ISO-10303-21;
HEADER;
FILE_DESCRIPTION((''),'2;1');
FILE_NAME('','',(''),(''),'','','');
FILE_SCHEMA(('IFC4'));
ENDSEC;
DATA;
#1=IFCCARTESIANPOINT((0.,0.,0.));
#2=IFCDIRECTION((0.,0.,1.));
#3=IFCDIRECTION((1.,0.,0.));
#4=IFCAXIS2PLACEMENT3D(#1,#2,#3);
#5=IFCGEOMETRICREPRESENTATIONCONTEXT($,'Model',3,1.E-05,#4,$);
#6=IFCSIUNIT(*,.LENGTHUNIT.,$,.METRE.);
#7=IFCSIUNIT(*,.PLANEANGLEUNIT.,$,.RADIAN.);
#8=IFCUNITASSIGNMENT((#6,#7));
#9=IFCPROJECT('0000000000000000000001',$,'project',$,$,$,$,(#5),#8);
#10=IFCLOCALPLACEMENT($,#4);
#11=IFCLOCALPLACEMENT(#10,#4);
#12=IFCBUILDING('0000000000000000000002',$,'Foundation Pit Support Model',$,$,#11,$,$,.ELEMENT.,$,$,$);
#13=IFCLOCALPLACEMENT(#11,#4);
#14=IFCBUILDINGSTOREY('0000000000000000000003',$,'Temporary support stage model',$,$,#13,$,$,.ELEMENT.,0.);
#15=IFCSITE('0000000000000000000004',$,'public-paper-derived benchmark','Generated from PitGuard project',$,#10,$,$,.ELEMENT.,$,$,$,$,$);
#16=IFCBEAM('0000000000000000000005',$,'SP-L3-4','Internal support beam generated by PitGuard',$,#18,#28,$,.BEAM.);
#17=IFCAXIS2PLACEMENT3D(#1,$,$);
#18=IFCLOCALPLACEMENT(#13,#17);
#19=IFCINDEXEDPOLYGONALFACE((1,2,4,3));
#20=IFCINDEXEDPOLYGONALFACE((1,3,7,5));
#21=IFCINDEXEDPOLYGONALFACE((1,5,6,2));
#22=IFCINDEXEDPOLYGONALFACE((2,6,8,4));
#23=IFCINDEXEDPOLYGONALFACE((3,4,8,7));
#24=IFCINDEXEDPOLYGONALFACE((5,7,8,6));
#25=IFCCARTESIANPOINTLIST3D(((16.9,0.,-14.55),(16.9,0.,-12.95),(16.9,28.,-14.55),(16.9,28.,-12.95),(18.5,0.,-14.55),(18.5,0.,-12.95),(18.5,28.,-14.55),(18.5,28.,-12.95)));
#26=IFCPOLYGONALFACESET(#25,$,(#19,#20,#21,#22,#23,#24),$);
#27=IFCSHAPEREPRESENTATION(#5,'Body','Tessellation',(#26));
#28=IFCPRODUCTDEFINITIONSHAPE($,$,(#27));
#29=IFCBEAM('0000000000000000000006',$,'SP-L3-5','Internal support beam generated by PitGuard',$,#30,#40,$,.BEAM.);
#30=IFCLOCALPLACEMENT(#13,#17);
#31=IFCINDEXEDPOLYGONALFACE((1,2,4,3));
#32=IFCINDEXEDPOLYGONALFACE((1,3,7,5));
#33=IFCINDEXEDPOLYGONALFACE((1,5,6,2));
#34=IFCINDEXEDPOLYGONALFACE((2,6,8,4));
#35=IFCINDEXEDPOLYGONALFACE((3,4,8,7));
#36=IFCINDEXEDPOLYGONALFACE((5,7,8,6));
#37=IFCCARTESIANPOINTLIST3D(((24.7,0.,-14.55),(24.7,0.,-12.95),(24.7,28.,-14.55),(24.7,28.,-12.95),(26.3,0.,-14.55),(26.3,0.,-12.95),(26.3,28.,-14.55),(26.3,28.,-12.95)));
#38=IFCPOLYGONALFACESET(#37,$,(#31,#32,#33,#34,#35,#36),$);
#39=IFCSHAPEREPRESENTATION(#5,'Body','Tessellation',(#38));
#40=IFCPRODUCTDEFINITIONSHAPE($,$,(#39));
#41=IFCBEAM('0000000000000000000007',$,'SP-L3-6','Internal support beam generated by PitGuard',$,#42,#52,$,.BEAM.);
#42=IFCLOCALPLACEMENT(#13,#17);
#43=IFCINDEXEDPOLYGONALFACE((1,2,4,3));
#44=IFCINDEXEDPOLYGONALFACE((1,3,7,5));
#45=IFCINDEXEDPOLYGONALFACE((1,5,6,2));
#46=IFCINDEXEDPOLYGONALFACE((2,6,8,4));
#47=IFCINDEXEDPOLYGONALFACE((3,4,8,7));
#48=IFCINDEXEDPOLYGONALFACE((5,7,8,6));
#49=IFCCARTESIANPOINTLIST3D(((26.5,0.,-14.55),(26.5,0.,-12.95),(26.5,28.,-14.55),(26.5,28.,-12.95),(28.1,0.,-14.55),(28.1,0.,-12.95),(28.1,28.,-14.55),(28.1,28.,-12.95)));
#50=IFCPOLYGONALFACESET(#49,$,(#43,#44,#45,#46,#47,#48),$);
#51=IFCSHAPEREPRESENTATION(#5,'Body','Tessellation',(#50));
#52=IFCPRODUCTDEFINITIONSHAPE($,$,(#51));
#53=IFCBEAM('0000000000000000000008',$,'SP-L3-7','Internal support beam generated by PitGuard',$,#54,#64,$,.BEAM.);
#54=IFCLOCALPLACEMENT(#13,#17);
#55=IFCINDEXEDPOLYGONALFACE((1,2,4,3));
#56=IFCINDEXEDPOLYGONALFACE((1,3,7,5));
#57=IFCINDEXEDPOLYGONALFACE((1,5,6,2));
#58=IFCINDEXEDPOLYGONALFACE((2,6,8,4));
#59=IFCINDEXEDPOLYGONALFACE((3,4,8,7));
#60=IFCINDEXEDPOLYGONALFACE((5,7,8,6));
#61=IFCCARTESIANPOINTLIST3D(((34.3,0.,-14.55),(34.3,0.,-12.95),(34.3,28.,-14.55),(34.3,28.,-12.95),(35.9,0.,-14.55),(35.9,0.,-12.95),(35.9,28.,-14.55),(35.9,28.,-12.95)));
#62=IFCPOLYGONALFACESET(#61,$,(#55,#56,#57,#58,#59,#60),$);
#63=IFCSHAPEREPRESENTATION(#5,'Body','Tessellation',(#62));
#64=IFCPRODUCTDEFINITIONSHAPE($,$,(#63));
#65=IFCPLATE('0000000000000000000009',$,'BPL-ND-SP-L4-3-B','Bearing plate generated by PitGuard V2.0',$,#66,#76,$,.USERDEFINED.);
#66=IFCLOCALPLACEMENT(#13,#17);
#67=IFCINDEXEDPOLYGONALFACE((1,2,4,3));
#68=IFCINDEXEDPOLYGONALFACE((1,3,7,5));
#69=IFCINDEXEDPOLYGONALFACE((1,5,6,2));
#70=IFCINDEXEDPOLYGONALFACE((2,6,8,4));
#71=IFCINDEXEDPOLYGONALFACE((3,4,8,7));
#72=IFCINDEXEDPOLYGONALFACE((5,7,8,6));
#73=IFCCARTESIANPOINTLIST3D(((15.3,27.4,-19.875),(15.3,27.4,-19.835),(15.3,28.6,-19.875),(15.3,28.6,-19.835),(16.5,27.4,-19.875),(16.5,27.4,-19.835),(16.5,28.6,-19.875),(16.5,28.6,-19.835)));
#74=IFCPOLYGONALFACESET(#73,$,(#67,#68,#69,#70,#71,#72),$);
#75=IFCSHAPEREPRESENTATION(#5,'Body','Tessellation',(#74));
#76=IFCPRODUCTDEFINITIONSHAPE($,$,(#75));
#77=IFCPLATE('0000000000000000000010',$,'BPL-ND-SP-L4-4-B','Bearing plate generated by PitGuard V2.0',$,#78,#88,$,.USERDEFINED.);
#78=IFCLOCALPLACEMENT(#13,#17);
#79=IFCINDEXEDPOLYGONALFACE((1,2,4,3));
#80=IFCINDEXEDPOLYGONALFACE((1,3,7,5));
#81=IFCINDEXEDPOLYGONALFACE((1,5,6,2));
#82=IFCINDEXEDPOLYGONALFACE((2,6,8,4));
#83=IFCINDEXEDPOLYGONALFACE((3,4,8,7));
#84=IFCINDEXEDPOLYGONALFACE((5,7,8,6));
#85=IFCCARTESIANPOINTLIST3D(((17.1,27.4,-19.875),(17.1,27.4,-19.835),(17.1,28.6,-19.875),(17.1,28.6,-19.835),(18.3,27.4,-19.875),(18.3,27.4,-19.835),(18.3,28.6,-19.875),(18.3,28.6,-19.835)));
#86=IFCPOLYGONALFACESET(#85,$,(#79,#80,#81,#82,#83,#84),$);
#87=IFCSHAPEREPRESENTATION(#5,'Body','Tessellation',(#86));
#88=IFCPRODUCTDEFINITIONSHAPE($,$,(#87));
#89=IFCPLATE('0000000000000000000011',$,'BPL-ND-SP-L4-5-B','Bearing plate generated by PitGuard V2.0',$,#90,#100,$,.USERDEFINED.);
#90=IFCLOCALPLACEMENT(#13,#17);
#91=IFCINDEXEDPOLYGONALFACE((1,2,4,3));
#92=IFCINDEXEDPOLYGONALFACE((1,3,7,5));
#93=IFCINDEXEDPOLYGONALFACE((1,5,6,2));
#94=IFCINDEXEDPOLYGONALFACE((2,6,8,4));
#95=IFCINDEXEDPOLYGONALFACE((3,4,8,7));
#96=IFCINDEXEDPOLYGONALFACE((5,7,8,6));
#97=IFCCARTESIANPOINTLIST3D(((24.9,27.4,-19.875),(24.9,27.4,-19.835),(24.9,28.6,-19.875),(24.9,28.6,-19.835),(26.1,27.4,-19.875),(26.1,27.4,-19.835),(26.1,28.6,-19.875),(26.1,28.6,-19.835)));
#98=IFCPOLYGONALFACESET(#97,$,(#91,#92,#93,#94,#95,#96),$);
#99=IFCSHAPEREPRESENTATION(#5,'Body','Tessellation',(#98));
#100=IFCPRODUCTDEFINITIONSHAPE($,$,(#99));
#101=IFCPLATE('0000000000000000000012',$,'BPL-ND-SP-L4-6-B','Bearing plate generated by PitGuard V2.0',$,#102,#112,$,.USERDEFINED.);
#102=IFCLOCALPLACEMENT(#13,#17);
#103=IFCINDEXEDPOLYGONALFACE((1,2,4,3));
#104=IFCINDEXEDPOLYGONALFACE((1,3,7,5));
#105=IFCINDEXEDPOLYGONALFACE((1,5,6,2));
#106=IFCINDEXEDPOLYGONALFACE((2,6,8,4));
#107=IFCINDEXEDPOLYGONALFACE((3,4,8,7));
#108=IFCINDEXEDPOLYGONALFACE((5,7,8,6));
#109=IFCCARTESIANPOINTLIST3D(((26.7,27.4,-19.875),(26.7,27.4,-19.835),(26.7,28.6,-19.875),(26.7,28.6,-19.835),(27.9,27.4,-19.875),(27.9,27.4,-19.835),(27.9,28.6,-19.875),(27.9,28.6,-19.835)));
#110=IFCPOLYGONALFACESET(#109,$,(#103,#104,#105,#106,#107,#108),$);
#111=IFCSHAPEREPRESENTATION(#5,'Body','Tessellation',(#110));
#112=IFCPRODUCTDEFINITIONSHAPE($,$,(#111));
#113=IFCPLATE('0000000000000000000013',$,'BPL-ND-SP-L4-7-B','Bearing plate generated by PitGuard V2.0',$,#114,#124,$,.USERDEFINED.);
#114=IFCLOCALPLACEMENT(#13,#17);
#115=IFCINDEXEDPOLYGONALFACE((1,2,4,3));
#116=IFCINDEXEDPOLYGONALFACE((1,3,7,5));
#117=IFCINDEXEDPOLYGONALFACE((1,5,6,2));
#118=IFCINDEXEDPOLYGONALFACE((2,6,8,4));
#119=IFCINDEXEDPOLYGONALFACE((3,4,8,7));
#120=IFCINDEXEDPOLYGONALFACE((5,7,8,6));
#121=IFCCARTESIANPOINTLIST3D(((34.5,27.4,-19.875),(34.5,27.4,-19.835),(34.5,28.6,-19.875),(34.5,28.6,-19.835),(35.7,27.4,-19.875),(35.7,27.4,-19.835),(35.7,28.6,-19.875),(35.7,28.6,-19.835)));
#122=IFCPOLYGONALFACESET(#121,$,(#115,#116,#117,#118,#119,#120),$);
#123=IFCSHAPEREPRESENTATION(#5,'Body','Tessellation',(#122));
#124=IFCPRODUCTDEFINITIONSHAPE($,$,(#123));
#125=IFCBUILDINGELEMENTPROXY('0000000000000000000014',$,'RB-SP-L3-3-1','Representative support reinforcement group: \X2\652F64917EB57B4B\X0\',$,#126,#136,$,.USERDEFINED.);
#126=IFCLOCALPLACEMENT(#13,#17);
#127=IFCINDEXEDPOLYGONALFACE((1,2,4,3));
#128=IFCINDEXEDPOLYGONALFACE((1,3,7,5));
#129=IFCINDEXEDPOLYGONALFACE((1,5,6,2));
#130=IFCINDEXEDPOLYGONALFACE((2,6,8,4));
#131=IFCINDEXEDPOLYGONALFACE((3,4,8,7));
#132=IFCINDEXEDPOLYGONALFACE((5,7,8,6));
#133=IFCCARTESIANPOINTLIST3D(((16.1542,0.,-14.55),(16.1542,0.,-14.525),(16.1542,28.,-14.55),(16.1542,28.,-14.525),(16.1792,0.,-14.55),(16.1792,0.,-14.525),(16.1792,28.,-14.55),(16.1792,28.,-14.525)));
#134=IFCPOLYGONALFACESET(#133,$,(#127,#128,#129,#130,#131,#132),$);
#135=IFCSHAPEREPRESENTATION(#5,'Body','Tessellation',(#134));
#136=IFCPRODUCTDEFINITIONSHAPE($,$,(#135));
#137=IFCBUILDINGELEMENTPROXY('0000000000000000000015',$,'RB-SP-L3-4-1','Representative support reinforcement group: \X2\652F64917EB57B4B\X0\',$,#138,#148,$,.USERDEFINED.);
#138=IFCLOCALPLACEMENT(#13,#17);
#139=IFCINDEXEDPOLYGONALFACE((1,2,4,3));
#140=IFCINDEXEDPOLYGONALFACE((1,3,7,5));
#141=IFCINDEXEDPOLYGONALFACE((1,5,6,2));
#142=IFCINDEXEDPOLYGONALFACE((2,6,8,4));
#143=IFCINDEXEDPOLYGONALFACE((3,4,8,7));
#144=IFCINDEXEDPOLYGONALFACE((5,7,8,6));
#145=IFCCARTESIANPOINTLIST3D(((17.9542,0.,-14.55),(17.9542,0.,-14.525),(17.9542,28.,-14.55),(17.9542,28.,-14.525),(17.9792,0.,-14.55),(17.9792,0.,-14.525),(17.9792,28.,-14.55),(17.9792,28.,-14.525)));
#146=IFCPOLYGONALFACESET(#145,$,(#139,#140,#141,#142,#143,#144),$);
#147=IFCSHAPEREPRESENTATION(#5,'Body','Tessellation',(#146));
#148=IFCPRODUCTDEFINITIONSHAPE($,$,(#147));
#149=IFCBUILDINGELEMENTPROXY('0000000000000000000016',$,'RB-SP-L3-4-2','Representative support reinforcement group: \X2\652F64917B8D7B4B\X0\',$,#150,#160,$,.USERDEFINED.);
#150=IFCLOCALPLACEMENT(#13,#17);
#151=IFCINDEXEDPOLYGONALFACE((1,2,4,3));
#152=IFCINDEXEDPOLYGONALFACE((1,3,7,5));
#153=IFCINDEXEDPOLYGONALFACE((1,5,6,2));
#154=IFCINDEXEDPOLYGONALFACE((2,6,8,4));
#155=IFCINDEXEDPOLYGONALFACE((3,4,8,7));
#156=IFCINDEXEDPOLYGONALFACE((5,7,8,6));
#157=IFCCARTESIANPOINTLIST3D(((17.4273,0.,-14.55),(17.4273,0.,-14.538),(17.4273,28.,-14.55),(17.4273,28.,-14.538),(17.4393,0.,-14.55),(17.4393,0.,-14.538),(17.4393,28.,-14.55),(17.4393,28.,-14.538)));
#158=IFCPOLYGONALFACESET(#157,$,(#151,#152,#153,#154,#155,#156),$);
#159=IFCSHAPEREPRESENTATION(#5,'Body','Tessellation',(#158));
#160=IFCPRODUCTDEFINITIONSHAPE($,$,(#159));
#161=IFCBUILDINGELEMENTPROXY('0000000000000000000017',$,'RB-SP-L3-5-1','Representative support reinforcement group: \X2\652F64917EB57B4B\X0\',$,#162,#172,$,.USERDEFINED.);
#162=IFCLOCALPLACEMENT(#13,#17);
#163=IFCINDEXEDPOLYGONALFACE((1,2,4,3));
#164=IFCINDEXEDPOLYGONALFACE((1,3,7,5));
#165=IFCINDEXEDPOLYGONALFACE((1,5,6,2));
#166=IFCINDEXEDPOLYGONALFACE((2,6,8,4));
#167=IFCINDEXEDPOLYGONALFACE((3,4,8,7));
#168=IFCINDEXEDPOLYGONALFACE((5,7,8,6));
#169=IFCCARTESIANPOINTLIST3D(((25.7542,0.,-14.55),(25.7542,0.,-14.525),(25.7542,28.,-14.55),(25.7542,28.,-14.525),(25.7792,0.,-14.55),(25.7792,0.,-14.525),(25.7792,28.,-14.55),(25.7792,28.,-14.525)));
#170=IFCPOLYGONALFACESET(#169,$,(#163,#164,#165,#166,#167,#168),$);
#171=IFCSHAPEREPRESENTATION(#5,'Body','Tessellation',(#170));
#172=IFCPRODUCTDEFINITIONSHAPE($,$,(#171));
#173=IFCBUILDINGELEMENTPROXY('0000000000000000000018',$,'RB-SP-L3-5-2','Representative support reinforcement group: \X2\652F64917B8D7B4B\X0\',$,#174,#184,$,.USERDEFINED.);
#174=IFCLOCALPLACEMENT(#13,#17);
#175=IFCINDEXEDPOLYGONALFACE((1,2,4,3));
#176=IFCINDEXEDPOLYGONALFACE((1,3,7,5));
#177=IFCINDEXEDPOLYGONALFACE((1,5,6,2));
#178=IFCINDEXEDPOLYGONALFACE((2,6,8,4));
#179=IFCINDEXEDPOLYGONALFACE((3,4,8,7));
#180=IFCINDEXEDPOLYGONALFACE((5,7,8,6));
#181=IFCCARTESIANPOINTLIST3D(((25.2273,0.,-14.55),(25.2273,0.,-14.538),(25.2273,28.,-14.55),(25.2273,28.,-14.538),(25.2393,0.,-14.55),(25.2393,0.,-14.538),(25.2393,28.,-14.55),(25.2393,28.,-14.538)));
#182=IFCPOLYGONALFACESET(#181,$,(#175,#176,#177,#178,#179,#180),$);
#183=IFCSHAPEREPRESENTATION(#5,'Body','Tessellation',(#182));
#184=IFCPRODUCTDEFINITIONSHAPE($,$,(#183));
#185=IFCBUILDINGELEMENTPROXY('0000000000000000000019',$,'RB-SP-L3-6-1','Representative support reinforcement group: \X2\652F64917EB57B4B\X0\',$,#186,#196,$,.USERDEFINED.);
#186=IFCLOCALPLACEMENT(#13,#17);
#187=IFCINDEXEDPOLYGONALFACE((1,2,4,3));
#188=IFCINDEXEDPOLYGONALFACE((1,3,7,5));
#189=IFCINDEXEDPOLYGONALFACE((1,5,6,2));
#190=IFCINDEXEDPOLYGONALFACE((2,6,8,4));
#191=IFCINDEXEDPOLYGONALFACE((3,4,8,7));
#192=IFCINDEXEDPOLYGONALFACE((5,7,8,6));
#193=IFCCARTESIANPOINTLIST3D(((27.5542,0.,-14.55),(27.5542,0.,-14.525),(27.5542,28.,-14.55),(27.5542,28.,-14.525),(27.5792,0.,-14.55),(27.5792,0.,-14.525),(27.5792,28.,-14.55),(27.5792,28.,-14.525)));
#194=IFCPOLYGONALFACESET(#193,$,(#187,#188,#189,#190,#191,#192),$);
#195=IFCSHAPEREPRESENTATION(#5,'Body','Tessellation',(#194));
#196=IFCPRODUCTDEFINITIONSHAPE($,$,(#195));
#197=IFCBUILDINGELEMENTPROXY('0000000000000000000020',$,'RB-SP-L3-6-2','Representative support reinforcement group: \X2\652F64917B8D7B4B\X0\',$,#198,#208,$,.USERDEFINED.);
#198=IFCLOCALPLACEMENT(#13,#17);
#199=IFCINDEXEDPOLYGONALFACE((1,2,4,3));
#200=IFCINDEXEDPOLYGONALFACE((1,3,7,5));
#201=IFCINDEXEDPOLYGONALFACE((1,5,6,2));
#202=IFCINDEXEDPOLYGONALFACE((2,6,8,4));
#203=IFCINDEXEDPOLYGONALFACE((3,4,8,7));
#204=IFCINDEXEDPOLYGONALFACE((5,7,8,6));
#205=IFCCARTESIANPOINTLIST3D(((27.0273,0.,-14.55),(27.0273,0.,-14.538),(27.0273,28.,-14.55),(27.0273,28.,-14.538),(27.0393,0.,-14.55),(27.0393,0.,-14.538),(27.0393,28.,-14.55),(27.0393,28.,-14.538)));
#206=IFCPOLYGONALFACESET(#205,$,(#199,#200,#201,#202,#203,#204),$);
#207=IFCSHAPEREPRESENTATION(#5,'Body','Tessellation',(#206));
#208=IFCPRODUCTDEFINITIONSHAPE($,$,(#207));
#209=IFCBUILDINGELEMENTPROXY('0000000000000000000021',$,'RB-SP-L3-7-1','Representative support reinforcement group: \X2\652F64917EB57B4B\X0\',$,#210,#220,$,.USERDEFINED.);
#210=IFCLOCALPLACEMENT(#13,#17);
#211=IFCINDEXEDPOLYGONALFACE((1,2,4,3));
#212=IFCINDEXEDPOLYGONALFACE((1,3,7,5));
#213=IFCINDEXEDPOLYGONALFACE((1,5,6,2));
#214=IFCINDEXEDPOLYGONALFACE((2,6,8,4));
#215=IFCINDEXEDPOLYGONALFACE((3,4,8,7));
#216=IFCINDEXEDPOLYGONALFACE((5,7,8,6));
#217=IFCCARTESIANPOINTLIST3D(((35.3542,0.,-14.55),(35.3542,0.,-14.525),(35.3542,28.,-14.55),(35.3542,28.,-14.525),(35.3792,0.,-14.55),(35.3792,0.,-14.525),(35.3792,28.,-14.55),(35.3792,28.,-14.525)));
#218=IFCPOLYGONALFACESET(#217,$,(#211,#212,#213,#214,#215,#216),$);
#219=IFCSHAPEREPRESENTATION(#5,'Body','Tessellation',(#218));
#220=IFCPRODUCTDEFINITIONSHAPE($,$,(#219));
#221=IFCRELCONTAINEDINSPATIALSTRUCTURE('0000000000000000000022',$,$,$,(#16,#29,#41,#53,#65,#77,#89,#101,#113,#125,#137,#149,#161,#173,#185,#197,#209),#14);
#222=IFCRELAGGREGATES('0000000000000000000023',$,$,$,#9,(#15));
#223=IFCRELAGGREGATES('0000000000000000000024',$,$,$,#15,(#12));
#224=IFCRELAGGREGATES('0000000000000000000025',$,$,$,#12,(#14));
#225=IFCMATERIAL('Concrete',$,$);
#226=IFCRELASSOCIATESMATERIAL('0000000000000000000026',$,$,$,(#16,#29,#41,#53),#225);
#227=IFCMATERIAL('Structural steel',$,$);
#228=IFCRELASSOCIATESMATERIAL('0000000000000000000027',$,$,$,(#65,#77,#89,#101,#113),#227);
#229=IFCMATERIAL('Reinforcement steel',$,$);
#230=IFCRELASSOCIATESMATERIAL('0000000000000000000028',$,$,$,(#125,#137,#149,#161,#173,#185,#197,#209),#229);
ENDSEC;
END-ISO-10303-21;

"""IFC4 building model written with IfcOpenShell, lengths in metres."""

from ifc_helpers import new_model, si_unit, frame, origin_with_axes, origin_2d, place, context, project, spatial, rectangle, extrude, material, element, save


model = new_model("IFC4")

# Units and contexts
model_context = context("Model", 3, precision=1e-05, world=origin_with_axes())
ifc_project = project(units=[si_unit("LENGTHUNIT", "METRE"), si_unit("PLANEANGLEUNIT", "RADIAN")], contexts=[model_context])

# Site, building, storey
site_placement = place(None, origin_with_axes())
site = spatial("IfcSite", under=ifc_project, at=site_placement, Name="public-paper-derived benchmark", Description="Generated from PitGuard project", CompositionType="ELEMENT")
building_placement = place(site_placement, origin_with_axes())
building = spatial("IfcBuilding", under=site, at=building_placement, Name="Foundation Pit Support Model", CompositionType="ELEMENT")
storey_placement = place(building_placement, origin_with_axes())
storey = spatial("IfcBuildingStorey", under=building, at=storey_placement, Name="Temporary support stage model", CompositionType="ELEMENT", Elevation=0.0)

# Beams
ifc_material_1 = material(Name="Concrete")
for number, where, z_axis, x_axis, name in (
    (1, (17.7, 14.0, -14.55), (0.0, 0.0, 1.0), (0.0, 1.0, 0.0), "SP-L3-4"),
    (2, (25.5, 14.0, -14.55), (0.0, 0.0, 1.0), (0.0, 1.0, 0.0), "SP-L3-5"),
    (3, (27.3, 14.0, -14.55), (0.0, 0.0, 1.0), (0.0, 1.0, 0.0), "SP-L3-6"),
    (4, (35.1, 14.0, -14.55), (0.0, 0.0, 1.0), (0.0, 1.0, 0.0), "SP-L3-7"),
):
    element("IfcBeam", number, at=place(storey_placement, frame(where, z_axis=z_axis, x_axis=x_axis)), inside=storey, material=ifc_material_1, Name=name, Description="Internal support beam generated by PitGuard", PredefinedType="BEAM", context=model_context, shape_type="SweptSolid", body=[
        extrude(rectangle(XDim=28.0, YDim=1.6, at=origin_2d()), origin_with_axes(), (0.0, 0.0, 1.0), 1.6),
    ])

# Plates
ifc_material_2 = material(Name="Structural steel")
for number, where, z_axis, x_axis, name in (
    (5, (15.9, 28.0, -19.875), (0.0, 0.0, 1.0), (1.0, 0.0, 0.0), "BPL-ND-SP-L4-3-B"),
    (6, (17.7, 28.0, -19.875), (0.0, 0.0, 1.0), (1.0, 0.0, 0.0), "BPL-ND-SP-L4-4-B"),
    (7, (25.5, 28.0, -19.875), (0.0, 0.0, 1.0), (1.0, 0.0, 0.0), "BPL-ND-SP-L4-5-B"),
    (8, (27.3, 28.0, -19.875), (0.0, 0.0, 1.0), (1.0, 0.0, 0.0), "BPL-ND-SP-L4-6-B"),
    (9, (35.1, 28.0, -19.875), (0.0, 0.0, 1.0), (1.0, 0.0, 0.0), "BPL-ND-SP-L4-7-B"),
):
    element("IfcPlate", number, at=place(storey_placement, frame(where, z_axis=z_axis, x_axis=x_axis)), inside=storey, material=ifc_material_2, Name=name, Description="Bearing plate generated by PitGuard V2.0", PredefinedType="USERDEFINED", context=model_context, shape_type="SweptSolid", body=[
        extrude(rectangle(XDim=1.2, YDim=1.2, at=origin_2d()), origin_with_axes(), (0.0, 0.0, 1.0), 0.04),
    ])

# Building element proxies
ifc_material_3 = material(Name="Reinforcement steel")
for number, where, z_axis, x_axis, name in (
    (10, (16.1667, 14.0, -14.55), (0.0, 0.0, 1.0), (0.0, 1.0, 0.0), "RB-SP-L3-3-1"),
    (11, (17.9667, 14.0, -14.55), (0.0, 0.0, 1.0), (0.0, 1.0, 0.0), "RB-SP-L3-4-1"),
):
    element("IfcBuildingElementProxy", number, at=place(storey_placement, frame(where, z_axis=z_axis, x_axis=x_axis)), inside=storey, material=ifc_material_3, Name=name, Description="Representative support reinforcement group: 支撑纵筋", PredefinedType="USERDEFINED", context=model_context, shape_type="SweptSolid", body=[
        extrude(rectangle(XDim=28.0, YDim=0.025, at=origin_2d()), origin_with_axes(), (0.0, 0.0, 1.0), 0.025),
    ])
proxy_1_placement = place(storey_placement, frame((17.4333, 14.0, -14.55), z_axis=(0.0, 0.0, 1.0), x_axis=(0.0, 1.0, 0.0)))
element("IfcBuildingElementProxy", 12, at=proxy_1_placement, inside=storey, material=ifc_material_3, Name="RB-SP-L3-4-2", Description="Representative support reinforcement group: 支撑箍筋", PredefinedType="USERDEFINED", context=model_context, shape_type="SweptSolid", body=[
    extrude(rectangle(XDim=28.0, YDim=0.012, at=origin_2d()), origin_with_axes(), (0.0, 0.0, 1.0), 0.012),
])
proxy_2_placement = place(storey_placement, frame((25.7667, 14.0, -14.55), z_axis=(0.0, 0.0, 1.0), x_axis=(0.0, 1.0, 0.0)))
element("IfcBuildingElementProxy", 13, at=proxy_2_placement, inside=storey, material=ifc_material_3, Name="RB-SP-L3-5-1", Description="Representative support reinforcement group: 支撑纵筋", PredefinedType="USERDEFINED", context=model_context, shape_type="SweptSolid", body=[
    extrude(rectangle(XDim=28.0, YDim=0.025, at=origin_2d()), origin_with_axes(), (0.0, 0.0, 1.0), 0.025),
])
proxy_3_placement = place(storey_placement, frame((25.2333, 14.0, -14.55), z_axis=(0.0, 0.0, 1.0), x_axis=(0.0, 1.0, 0.0)))
element("IfcBuildingElementProxy", 14, at=proxy_3_placement, inside=storey, material=ifc_material_3, Name="RB-SP-L3-5-2", Description="Representative support reinforcement group: 支撑箍筋", PredefinedType="USERDEFINED", context=model_context, shape_type="SweptSolid", body=[
    extrude(rectangle(XDim=28.0, YDim=0.012, at=origin_2d()), origin_with_axes(), (0.0, 0.0, 1.0), 0.012),
])
proxy_4_placement = place(storey_placement, frame((27.5667, 14.0, -14.55), z_axis=(0.0, 0.0, 1.0), x_axis=(0.0, 1.0, 0.0)))
element("IfcBuildingElementProxy", 15, at=proxy_4_placement, inside=storey, material=ifc_material_3, Name="RB-SP-L3-6-1", Description="Representative support reinforcement group: 支撑纵筋", PredefinedType="USERDEFINED", context=model_context, shape_type="SweptSolid", body=[
    extrude(rectangle(XDim=28.0, YDim=0.025, at=origin_2d()), origin_with_axes(), (0.0, 0.0, 1.0), 0.025),
])
proxy_5_placement = place(storey_placement, frame((27.0333, 14.0, -14.55), z_axis=(0.0, 0.0, 1.0), x_axis=(0.0, 1.0, 0.0)))
element("IfcBuildingElementProxy", 16, at=proxy_5_placement, inside=storey, material=ifc_material_3, Name="RB-SP-L3-6-2", Description="Representative support reinforcement group: 支撑箍筋", PredefinedType="USERDEFINED", context=model_context, shape_type="SweptSolid", body=[
    extrude(rectangle(XDim=28.0, YDim=0.012, at=origin_2d()), origin_with_axes(), (0.0, 0.0, 1.0), 0.012),
])
proxy_6_placement = place(storey_placement, frame((35.3667, 14.0, -14.55), z_axis=(0.0, 0.0, 1.0), x_axis=(0.0, 1.0, 0.0)))
element("IfcBuildingElementProxy", 17, at=proxy_6_placement, inside=storey, material=ifc_material_3, Name="RB-SP-L3-7-1", Description="Representative support reinforcement group: 支撑纵筋", PredefinedType="USERDEFINED", context=model_context, shape_type="SweptSolid", body=[
    extrude(rectangle(XDim=28.0, YDim=0.025, at=origin_2d()), origin_with_axes(), (0.0, 0.0, 1.0), 0.025),
])

save(model, "model.ifc")
